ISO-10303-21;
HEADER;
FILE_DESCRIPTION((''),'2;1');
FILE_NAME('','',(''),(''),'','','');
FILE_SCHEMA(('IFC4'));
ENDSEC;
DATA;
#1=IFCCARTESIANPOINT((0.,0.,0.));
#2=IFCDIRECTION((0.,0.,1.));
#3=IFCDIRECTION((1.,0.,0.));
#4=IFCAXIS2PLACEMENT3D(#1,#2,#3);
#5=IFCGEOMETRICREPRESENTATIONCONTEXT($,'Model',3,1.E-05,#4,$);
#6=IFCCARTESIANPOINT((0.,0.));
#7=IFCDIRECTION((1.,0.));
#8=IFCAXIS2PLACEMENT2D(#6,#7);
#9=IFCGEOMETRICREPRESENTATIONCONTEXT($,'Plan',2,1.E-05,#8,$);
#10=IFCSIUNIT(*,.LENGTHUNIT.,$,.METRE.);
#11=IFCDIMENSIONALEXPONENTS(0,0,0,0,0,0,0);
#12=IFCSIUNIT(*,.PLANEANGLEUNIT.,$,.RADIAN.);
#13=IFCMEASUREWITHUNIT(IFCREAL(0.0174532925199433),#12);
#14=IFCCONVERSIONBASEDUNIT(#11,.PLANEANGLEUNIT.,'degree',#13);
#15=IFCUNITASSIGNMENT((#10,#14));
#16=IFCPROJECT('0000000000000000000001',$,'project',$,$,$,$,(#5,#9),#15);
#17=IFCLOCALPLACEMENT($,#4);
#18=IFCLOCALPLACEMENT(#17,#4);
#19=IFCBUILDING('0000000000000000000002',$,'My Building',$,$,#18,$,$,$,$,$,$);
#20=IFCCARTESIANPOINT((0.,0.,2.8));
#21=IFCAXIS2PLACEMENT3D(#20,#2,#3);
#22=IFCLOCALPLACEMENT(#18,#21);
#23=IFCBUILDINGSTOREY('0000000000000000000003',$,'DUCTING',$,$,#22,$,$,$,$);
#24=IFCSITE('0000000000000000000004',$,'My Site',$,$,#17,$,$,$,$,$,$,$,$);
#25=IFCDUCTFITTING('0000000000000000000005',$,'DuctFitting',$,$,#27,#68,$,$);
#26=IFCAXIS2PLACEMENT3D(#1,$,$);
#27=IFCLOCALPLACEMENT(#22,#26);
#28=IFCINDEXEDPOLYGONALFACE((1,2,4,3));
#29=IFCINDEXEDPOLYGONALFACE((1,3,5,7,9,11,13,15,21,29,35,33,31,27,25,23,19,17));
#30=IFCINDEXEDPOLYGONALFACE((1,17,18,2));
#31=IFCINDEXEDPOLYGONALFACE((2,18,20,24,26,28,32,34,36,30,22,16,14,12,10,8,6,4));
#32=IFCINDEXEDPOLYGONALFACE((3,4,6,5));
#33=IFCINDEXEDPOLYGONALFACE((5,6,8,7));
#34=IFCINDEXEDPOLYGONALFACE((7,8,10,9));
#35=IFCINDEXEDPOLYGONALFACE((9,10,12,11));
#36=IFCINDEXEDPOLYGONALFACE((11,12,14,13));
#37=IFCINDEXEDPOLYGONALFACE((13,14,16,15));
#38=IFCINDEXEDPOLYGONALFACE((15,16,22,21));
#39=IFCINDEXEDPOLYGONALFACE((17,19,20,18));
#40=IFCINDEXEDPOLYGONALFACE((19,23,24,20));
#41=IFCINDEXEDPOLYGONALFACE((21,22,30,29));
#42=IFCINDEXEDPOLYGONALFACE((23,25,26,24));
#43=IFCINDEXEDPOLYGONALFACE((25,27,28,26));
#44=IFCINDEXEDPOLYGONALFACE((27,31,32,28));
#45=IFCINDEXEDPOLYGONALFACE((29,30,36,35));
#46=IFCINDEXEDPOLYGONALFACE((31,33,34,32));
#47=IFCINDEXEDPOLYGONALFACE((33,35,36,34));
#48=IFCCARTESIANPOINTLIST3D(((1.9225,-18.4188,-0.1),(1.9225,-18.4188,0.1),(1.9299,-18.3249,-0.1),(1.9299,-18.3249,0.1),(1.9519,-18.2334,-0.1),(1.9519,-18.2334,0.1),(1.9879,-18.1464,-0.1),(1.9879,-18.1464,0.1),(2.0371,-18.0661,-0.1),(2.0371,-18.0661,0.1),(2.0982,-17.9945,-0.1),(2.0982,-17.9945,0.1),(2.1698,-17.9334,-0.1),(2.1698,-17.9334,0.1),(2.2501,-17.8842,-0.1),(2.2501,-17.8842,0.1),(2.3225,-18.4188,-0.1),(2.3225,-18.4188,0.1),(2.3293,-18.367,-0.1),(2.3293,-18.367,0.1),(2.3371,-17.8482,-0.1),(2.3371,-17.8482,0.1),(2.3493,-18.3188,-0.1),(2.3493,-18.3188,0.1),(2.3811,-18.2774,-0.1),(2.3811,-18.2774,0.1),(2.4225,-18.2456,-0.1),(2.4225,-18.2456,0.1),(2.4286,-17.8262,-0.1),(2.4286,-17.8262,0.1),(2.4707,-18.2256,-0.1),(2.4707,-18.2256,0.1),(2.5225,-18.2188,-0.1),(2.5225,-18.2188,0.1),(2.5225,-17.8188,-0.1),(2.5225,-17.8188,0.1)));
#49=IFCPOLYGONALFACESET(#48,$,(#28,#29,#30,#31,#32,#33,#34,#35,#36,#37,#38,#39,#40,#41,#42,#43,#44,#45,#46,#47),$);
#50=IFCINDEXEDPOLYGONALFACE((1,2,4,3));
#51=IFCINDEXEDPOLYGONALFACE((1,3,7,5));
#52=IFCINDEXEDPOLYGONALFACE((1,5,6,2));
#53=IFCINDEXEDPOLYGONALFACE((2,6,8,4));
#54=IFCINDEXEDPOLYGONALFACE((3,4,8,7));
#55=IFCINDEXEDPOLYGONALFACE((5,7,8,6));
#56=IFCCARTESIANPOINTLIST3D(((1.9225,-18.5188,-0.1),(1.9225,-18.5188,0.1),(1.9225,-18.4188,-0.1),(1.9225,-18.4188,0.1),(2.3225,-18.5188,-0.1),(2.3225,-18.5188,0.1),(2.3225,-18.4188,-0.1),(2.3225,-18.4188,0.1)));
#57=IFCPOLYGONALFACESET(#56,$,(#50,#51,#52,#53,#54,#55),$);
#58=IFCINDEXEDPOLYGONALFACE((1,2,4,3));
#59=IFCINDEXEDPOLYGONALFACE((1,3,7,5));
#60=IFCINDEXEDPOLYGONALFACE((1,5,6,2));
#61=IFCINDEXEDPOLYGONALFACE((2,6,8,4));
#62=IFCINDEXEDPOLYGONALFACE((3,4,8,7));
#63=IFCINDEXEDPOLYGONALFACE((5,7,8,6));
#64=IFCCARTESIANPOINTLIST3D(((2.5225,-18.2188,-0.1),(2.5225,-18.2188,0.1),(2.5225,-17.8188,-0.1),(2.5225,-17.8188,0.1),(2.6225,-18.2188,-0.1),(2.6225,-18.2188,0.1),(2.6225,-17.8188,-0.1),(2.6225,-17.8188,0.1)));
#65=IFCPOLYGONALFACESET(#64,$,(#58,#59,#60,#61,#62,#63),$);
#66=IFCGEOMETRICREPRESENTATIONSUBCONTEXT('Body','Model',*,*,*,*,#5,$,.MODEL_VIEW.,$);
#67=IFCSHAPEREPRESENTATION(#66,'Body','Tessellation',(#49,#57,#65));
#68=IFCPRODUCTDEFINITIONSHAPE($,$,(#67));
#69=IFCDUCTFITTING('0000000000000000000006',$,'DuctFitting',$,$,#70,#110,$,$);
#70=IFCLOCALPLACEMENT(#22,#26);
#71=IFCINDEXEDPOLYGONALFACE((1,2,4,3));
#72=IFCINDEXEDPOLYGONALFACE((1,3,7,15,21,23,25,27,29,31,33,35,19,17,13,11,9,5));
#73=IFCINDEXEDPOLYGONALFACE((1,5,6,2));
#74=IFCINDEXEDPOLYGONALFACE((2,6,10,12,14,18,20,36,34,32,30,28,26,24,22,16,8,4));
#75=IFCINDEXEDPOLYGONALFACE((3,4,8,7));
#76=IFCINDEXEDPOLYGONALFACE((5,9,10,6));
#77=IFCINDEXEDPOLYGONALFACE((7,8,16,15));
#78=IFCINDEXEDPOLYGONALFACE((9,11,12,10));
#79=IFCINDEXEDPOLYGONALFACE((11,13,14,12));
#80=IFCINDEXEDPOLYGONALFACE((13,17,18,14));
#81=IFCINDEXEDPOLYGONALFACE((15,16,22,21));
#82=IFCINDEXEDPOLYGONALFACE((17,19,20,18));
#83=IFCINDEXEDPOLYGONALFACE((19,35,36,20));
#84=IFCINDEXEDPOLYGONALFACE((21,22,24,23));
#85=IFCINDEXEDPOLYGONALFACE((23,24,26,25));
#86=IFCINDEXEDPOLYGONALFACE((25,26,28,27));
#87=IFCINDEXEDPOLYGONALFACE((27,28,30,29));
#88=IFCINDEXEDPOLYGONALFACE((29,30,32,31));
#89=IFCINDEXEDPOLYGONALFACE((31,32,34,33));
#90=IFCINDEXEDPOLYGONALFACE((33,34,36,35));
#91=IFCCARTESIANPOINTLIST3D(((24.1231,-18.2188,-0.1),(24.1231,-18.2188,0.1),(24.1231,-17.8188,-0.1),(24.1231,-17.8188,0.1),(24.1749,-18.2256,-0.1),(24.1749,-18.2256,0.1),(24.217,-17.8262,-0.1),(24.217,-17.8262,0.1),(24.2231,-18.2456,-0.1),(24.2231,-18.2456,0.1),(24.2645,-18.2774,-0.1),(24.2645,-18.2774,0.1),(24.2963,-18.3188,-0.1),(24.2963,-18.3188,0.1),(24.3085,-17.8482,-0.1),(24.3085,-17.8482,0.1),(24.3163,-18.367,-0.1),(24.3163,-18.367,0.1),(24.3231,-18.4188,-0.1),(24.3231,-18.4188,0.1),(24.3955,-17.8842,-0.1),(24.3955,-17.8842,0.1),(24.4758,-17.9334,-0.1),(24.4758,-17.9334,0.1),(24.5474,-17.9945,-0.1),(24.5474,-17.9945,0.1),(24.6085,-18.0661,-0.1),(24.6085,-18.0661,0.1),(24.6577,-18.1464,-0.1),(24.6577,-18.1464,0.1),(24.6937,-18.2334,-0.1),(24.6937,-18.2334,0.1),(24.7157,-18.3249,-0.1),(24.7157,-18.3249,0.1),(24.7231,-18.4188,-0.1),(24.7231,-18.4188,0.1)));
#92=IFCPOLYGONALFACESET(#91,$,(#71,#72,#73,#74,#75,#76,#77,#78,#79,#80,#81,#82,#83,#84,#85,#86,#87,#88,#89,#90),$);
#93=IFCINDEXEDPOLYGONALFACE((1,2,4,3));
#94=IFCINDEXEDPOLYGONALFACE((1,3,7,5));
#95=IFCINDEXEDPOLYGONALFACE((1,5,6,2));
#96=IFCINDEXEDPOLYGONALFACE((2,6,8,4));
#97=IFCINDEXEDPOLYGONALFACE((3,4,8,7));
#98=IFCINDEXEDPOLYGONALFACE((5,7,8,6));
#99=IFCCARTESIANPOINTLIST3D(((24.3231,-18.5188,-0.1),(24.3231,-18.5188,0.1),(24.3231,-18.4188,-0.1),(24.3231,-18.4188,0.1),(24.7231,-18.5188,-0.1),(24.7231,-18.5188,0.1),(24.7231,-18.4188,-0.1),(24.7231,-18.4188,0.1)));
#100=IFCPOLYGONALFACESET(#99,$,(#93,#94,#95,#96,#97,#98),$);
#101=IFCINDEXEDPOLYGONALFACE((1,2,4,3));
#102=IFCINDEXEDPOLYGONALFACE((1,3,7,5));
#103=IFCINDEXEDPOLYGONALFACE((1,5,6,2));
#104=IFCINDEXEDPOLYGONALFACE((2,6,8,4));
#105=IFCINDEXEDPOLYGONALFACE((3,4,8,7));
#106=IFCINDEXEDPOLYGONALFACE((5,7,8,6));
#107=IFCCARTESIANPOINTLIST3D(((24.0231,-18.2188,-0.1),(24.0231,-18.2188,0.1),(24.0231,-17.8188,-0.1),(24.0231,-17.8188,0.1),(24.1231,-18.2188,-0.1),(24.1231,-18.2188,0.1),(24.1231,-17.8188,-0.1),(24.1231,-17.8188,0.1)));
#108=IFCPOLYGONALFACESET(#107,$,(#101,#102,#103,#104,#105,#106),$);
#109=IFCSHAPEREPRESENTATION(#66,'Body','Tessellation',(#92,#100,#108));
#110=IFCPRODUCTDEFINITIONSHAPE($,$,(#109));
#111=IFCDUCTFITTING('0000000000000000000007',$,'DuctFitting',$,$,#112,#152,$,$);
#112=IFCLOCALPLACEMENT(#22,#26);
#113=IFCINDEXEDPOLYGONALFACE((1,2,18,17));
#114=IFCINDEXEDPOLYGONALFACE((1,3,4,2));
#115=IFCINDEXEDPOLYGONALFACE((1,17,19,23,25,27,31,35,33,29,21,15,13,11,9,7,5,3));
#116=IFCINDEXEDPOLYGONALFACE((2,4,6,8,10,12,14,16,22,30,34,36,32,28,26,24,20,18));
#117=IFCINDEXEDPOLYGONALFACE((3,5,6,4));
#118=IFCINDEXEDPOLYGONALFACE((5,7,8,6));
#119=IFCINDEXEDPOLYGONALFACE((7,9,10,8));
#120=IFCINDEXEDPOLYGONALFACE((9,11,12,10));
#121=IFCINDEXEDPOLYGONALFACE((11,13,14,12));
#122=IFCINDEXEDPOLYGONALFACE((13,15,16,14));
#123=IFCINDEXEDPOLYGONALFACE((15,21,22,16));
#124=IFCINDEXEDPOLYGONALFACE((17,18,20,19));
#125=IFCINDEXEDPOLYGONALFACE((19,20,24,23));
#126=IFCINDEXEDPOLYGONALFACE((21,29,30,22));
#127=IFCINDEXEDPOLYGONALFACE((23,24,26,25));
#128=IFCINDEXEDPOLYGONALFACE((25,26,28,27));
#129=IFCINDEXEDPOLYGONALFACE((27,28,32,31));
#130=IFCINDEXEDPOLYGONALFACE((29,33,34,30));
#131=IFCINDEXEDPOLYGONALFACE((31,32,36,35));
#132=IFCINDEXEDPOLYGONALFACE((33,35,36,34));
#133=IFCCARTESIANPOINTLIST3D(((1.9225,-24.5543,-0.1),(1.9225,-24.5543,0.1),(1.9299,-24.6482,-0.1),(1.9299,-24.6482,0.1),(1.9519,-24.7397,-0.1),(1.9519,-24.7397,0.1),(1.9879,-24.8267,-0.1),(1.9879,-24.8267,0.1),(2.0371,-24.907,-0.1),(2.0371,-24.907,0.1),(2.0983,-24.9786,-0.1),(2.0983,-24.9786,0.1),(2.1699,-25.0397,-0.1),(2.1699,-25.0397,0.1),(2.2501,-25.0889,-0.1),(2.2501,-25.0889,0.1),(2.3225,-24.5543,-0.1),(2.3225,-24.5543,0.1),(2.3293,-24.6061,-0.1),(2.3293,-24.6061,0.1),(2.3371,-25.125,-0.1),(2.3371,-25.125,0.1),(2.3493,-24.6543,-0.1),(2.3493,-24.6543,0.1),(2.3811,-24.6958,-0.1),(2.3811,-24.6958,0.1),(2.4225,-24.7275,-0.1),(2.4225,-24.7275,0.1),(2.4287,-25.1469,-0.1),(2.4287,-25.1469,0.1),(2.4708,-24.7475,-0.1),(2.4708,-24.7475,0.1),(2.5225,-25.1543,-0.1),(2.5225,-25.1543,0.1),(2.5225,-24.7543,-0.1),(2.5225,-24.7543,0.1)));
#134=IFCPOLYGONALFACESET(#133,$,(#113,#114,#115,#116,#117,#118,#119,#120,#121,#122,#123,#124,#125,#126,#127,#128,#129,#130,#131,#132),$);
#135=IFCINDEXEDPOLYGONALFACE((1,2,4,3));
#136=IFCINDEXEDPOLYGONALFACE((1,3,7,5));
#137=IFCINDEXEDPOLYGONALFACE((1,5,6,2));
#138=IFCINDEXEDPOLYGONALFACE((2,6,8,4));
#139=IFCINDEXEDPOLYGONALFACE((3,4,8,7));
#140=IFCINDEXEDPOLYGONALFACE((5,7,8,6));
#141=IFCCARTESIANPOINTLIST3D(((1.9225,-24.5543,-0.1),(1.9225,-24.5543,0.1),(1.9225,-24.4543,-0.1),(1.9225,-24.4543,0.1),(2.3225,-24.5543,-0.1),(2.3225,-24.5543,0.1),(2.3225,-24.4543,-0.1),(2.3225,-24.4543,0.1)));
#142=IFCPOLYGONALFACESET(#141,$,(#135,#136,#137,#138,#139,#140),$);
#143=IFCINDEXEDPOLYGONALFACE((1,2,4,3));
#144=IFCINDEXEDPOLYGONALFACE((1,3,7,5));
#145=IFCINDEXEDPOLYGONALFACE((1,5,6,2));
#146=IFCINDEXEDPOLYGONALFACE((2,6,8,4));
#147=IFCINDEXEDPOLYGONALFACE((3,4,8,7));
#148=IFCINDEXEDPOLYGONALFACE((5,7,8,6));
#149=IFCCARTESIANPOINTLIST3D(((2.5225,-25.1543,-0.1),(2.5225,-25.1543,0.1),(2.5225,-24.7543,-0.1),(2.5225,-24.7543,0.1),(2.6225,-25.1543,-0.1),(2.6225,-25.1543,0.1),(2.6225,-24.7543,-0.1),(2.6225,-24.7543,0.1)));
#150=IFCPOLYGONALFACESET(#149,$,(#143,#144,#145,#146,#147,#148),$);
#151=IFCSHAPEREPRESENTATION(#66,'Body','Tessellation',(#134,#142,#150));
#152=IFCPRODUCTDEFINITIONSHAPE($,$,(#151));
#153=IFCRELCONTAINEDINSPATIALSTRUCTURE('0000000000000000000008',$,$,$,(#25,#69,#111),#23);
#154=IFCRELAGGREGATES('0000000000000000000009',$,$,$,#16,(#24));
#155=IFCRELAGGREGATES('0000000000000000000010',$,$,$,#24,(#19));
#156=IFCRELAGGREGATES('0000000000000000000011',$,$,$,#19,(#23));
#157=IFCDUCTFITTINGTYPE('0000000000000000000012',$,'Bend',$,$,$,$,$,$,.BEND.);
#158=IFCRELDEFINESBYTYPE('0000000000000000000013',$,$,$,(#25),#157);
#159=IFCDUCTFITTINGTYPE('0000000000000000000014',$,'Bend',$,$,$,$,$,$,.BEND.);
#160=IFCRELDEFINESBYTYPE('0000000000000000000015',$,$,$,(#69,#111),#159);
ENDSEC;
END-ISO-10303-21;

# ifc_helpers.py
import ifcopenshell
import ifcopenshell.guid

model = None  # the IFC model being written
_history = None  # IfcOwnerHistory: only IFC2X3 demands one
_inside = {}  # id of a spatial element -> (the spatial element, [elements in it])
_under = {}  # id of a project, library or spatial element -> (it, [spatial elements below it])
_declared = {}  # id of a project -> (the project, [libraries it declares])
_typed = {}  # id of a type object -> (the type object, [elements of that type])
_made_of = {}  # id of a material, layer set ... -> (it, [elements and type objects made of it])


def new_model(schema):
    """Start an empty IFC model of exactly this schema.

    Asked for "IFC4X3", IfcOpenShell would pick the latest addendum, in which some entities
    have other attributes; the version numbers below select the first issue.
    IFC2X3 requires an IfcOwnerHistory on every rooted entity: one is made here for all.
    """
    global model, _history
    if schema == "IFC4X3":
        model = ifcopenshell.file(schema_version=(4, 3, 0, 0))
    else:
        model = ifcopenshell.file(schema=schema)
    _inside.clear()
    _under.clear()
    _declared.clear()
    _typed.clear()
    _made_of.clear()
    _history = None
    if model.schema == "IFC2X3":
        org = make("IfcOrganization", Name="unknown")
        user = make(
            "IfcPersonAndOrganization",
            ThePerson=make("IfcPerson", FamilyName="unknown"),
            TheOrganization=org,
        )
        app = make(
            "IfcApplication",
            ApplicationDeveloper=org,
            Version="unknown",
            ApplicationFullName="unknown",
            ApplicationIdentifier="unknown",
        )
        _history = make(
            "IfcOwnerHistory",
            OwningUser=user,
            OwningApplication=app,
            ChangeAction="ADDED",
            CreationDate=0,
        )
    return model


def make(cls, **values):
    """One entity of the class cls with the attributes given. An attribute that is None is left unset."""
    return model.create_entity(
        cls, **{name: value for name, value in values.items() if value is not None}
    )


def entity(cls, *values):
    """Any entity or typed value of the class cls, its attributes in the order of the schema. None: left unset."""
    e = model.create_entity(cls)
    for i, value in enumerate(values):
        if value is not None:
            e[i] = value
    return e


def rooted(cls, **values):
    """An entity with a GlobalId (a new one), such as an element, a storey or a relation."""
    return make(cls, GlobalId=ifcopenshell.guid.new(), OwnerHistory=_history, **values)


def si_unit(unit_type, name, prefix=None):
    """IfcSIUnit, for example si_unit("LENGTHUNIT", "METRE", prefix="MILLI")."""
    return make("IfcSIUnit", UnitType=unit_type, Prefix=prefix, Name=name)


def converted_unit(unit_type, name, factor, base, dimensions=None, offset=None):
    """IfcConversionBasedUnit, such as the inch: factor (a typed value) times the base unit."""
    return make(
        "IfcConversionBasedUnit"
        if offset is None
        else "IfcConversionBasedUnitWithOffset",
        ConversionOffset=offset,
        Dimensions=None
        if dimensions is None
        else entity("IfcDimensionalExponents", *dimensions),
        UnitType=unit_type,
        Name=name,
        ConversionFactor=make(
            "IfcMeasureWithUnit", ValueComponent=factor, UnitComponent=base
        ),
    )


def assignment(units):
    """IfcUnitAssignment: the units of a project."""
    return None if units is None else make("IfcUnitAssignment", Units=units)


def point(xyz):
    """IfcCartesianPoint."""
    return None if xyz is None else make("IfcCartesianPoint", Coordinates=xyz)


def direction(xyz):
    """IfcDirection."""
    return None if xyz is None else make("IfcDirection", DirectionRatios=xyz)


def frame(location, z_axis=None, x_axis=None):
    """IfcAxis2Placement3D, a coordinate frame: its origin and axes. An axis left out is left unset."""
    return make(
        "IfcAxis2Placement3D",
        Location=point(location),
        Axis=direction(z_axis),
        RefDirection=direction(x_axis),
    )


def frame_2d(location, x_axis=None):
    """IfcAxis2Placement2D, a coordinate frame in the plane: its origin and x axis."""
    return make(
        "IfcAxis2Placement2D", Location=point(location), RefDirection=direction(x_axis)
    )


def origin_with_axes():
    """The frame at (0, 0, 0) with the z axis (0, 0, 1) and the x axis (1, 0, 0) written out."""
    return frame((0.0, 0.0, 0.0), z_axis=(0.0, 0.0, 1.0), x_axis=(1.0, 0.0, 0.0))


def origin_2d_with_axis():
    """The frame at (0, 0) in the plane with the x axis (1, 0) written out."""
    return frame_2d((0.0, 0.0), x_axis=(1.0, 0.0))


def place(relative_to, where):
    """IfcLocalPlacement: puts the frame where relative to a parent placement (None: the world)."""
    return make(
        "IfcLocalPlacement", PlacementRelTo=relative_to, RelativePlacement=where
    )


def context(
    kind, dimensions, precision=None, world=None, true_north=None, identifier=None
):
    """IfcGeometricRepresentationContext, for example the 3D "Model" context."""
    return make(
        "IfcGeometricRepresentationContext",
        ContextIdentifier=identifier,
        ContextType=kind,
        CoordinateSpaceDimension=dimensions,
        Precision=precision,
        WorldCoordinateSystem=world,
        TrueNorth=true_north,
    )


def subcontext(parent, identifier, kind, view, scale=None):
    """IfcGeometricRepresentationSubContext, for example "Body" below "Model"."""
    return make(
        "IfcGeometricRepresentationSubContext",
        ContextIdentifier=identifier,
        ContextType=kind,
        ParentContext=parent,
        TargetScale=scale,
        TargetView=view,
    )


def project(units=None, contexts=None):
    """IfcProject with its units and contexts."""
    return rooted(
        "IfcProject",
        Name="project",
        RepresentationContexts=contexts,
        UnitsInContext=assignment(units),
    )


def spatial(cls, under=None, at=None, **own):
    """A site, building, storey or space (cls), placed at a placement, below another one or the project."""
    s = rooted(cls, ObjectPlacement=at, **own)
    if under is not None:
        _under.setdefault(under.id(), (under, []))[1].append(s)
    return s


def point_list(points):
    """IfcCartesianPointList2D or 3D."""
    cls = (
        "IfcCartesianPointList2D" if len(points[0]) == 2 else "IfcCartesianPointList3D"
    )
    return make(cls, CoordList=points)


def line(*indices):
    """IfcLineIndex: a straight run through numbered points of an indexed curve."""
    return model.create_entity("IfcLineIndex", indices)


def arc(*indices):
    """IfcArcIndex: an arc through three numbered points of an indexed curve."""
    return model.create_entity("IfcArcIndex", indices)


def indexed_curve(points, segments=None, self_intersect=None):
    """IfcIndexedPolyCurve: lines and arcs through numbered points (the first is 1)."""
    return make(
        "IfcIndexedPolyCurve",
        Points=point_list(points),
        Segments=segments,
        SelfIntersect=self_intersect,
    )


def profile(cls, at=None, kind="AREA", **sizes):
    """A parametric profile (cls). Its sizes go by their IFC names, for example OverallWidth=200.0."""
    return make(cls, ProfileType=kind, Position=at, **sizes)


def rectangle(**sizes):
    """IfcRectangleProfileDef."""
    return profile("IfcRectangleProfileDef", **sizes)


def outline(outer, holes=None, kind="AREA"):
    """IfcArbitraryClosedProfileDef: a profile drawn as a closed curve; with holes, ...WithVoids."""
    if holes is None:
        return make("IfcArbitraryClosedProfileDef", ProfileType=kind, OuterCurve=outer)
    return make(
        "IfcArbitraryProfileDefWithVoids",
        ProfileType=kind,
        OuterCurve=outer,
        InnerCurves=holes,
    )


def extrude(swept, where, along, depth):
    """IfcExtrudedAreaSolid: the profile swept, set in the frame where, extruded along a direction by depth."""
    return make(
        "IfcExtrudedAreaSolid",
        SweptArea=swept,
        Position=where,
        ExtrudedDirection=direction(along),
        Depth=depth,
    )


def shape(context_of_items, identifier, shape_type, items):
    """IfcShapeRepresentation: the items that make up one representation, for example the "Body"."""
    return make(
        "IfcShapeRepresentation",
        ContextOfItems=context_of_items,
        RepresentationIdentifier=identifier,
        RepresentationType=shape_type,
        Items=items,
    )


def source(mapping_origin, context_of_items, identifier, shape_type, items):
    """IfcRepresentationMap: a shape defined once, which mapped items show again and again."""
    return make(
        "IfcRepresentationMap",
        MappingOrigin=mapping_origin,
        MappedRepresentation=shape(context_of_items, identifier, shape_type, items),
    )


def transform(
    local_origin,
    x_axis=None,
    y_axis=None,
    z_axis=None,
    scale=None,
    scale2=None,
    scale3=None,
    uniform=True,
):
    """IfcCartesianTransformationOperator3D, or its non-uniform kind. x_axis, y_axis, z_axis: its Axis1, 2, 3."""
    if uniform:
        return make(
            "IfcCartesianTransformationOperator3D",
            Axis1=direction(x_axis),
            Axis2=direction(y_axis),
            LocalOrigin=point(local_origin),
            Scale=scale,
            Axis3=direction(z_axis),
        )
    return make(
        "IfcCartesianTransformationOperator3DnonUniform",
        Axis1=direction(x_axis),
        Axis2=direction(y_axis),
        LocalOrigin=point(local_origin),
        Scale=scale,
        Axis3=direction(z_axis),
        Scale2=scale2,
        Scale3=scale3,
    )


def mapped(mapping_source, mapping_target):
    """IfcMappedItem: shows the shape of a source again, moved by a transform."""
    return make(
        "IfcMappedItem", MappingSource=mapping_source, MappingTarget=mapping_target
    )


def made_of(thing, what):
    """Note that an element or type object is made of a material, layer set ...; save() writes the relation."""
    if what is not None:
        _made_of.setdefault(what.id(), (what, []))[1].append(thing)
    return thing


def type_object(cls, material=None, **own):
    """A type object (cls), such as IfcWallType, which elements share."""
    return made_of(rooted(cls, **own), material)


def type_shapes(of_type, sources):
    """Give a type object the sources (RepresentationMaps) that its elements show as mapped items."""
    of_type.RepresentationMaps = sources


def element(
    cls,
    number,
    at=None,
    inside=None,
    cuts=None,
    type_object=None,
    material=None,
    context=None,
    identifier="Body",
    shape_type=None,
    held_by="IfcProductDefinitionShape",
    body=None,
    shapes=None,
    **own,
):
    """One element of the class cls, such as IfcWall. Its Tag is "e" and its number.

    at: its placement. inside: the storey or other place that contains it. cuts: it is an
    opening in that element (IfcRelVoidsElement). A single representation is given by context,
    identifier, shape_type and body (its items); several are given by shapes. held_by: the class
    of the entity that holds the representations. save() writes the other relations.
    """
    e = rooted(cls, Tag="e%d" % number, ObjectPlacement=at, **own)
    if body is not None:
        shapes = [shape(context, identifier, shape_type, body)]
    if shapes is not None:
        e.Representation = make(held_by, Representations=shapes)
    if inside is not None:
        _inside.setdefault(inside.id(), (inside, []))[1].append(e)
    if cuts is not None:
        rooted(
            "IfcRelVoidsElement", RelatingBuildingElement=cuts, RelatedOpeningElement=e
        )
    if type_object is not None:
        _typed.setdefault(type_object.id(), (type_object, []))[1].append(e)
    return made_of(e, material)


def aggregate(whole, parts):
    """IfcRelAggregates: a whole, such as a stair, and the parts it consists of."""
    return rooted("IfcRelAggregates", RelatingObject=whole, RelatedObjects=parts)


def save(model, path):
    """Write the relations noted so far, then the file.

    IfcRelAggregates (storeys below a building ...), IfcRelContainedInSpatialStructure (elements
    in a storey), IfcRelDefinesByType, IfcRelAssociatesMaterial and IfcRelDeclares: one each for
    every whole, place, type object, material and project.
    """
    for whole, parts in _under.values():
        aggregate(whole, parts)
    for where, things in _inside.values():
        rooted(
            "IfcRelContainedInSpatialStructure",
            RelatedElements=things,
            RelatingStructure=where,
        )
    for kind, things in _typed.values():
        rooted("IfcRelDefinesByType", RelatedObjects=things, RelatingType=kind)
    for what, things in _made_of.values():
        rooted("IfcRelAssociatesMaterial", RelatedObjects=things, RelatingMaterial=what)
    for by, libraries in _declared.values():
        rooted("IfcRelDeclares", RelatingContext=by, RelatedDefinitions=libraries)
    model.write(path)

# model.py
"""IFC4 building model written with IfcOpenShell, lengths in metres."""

from ifc_helpers import new_model, entity, si_unit, converted_unit, frame, origin_with_axes, origin_2d_with_axis, place, context, subcontext, project, spatial, line, arc, indexed_curve, rectangle, outline, extrude, source, transform, mapped, type_object, type_shapes, element, save


model = new_model("IFC4")

# Units and contexts
model_context = context("Model", 3, precision=1e-05, world=origin_with_axes())
plan_context = context("Plan", 2, precision=1e-05, world=origin_2d_with_axis())
body_context = subcontext(model_context, "Body", "Model", "MODEL_VIEW")
ifc_project = project(units=[si_unit("LENGTHUNIT", "METRE"), converted_unit("PLANEANGLEUNIT", "degree", entity("IfcReal", 0.0174532925199433), si_unit("PLANEANGLEUNIT", "RADIAN"), dimensions=[0, 0, 0, 0, 0, 0, 0])], contexts=[model_context, plan_context])

# Site, building, storey
site_placement = place(None, origin_with_axes())
site = spatial("IfcSite", under=ifc_project, at=site_placement, Name="My Site")
building_placement = place(site_placement, origin_with_axes())
building = spatial("IfcBuilding", under=site, at=building_placement, Name="My Building")
storey_placement = place(building_placement, frame((0.0, 0.0, 2.8), z_axis=(0.0, 0.0, 1.0), x_axis=(1.0, 0.0, 0.0)))
storey = spatial("IfcBuildingStorey", under=building, at=storey_placement, Name="DUCTING")

# Duct fittings
duct_fitting_type_1 = type_object("IfcDuctFittingType", Name="Bend", PredefinedType="BEND")
shared_shape_1 = source(origin_with_axes(), body_context, "Body", "SweptSolid", [
    extrude(outline(indexed_curve([(-0.2, 0.0), (-0.2586, 0.1414), (-0.4, 0.2), (-0.4, 0.6), (0.0243, 0.4243), (0.2, 0.0)], segments=[arc(1, 2, 3), line(3, 4), arc(4, 5, 6), line(6, 1)])), frame((0.0, -0.1, 0.1), z_axis=(0.0, -1.0, 0.0), x_axis=(1.0, 0.0, 0.0)), (0.0, 0.0, -1.0), 0.2),
    extrude(rectangle(XDim=0.4, YDim=0.2), origin_with_axes(), (0.0, 0.0, 1.0), 0.1),
    extrude(rectangle(XDim=0.4, YDim=0.2), frame((-0.4, 0.0, 0.5), z_axis=(-1.0, 0.0, -0.000007), x_axis=(0.000007, 0.0, -1.0)), (0.0, 0.0, 1.0), 0.1),
])
type_shapes(duct_fitting_type_1, [shared_shape_1])
for number, where, z_axis, x_axis, name in (
    (1, (2.1225, -18.5188, 0.0), (-0.000006, 1.0, 0.0), (-1.0, -0.000006, 0.0), "DuctFitting"),
):
    element("IfcDuctFitting", number, at=place(storey_placement, frame(where, z_axis=z_axis, x_axis=x_axis)), inside=storey, type_object=duct_fitting_type_1, Name=name, context=body_context, shape_type="MappedRepresentation", body=[
        mapped(shared_shape_1, transform((0.0, 0.0, 0.0), x_axis=(1.0, 0.0, 0.0), y_axis=(0.0, 1.0, 0.0), z_axis=(0.0, 0.0, 1.0), scale=1.0)),
    ])
duct_fitting_type_2 = type_object("IfcDuctFittingType", Name="Bend", PredefinedType="BEND")
shared_shape_2 = source(origin_with_axes(), body_context, "Body", "SweptSolid", [
    extrude(outline(indexed_curve([(-0.2, 0.0), (-0.2586, -0.1414), (-0.4, -0.2), (-0.4, -0.6), (0.0243, -0.4243), (0.2, 0.0)], segments=[arc(1, 2, 3), line(3, 4), arc(4, 5, 6), line(6, 1)])), frame((0.0, -0.1, -0.1), z_axis=(0.0, -1.0, 0.0), x_axis=(1.0, 0.0, 0.0)), (0.0, 0.0, -1.0), 0.2),
    extrude(rectangle(XDim=0.4, YDim=0.2), origin_with_axes(), (0.0, 0.0, -1.0), 0.1),
    extrude(rectangle(XDim=0.4, YDim=0.2), frame((-0.4, 0.0, -0.5), z_axis=(-1.0, 0.0, -0.000007), x_axis=(0.000007, 0.0, -1.0)), (0.0, 0.0, 1.0), 0.1),
])
type_shapes(duct_fitting_type_2, [shared_shape_2])
for number, where, z_axis, x_axis, name in (
    (2, (24.5231, -18.5188, 0.0), (0.000006, -1.0, 0.0), (1.0, 0.000006, 0.0), "DuctFitting"),
    (3, (2.1225, -24.4543, 0.0), (-0.000006, 1.0, 0.0), (-1.0, -0.000006, 0.0), "DuctFitting"),
):
    element("IfcDuctFitting", number, at=place(storey_placement, frame(where, z_axis=z_axis, x_axis=x_axis)), inside=storey, type_object=duct_fitting_type_2, Name=name, context=body_context, shape_type="MappedRepresentation", body=[
        mapped(shared_shape_2, transform((0.0, 0.0, 0.0), x_axis=(1.0, 0.0, 0.0), y_axis=(0.0, 1.0, 0.0), z_axis=(0.0, 0.0, 1.0), scale=1.0)),
    ])

save(model, "model.ifc")
